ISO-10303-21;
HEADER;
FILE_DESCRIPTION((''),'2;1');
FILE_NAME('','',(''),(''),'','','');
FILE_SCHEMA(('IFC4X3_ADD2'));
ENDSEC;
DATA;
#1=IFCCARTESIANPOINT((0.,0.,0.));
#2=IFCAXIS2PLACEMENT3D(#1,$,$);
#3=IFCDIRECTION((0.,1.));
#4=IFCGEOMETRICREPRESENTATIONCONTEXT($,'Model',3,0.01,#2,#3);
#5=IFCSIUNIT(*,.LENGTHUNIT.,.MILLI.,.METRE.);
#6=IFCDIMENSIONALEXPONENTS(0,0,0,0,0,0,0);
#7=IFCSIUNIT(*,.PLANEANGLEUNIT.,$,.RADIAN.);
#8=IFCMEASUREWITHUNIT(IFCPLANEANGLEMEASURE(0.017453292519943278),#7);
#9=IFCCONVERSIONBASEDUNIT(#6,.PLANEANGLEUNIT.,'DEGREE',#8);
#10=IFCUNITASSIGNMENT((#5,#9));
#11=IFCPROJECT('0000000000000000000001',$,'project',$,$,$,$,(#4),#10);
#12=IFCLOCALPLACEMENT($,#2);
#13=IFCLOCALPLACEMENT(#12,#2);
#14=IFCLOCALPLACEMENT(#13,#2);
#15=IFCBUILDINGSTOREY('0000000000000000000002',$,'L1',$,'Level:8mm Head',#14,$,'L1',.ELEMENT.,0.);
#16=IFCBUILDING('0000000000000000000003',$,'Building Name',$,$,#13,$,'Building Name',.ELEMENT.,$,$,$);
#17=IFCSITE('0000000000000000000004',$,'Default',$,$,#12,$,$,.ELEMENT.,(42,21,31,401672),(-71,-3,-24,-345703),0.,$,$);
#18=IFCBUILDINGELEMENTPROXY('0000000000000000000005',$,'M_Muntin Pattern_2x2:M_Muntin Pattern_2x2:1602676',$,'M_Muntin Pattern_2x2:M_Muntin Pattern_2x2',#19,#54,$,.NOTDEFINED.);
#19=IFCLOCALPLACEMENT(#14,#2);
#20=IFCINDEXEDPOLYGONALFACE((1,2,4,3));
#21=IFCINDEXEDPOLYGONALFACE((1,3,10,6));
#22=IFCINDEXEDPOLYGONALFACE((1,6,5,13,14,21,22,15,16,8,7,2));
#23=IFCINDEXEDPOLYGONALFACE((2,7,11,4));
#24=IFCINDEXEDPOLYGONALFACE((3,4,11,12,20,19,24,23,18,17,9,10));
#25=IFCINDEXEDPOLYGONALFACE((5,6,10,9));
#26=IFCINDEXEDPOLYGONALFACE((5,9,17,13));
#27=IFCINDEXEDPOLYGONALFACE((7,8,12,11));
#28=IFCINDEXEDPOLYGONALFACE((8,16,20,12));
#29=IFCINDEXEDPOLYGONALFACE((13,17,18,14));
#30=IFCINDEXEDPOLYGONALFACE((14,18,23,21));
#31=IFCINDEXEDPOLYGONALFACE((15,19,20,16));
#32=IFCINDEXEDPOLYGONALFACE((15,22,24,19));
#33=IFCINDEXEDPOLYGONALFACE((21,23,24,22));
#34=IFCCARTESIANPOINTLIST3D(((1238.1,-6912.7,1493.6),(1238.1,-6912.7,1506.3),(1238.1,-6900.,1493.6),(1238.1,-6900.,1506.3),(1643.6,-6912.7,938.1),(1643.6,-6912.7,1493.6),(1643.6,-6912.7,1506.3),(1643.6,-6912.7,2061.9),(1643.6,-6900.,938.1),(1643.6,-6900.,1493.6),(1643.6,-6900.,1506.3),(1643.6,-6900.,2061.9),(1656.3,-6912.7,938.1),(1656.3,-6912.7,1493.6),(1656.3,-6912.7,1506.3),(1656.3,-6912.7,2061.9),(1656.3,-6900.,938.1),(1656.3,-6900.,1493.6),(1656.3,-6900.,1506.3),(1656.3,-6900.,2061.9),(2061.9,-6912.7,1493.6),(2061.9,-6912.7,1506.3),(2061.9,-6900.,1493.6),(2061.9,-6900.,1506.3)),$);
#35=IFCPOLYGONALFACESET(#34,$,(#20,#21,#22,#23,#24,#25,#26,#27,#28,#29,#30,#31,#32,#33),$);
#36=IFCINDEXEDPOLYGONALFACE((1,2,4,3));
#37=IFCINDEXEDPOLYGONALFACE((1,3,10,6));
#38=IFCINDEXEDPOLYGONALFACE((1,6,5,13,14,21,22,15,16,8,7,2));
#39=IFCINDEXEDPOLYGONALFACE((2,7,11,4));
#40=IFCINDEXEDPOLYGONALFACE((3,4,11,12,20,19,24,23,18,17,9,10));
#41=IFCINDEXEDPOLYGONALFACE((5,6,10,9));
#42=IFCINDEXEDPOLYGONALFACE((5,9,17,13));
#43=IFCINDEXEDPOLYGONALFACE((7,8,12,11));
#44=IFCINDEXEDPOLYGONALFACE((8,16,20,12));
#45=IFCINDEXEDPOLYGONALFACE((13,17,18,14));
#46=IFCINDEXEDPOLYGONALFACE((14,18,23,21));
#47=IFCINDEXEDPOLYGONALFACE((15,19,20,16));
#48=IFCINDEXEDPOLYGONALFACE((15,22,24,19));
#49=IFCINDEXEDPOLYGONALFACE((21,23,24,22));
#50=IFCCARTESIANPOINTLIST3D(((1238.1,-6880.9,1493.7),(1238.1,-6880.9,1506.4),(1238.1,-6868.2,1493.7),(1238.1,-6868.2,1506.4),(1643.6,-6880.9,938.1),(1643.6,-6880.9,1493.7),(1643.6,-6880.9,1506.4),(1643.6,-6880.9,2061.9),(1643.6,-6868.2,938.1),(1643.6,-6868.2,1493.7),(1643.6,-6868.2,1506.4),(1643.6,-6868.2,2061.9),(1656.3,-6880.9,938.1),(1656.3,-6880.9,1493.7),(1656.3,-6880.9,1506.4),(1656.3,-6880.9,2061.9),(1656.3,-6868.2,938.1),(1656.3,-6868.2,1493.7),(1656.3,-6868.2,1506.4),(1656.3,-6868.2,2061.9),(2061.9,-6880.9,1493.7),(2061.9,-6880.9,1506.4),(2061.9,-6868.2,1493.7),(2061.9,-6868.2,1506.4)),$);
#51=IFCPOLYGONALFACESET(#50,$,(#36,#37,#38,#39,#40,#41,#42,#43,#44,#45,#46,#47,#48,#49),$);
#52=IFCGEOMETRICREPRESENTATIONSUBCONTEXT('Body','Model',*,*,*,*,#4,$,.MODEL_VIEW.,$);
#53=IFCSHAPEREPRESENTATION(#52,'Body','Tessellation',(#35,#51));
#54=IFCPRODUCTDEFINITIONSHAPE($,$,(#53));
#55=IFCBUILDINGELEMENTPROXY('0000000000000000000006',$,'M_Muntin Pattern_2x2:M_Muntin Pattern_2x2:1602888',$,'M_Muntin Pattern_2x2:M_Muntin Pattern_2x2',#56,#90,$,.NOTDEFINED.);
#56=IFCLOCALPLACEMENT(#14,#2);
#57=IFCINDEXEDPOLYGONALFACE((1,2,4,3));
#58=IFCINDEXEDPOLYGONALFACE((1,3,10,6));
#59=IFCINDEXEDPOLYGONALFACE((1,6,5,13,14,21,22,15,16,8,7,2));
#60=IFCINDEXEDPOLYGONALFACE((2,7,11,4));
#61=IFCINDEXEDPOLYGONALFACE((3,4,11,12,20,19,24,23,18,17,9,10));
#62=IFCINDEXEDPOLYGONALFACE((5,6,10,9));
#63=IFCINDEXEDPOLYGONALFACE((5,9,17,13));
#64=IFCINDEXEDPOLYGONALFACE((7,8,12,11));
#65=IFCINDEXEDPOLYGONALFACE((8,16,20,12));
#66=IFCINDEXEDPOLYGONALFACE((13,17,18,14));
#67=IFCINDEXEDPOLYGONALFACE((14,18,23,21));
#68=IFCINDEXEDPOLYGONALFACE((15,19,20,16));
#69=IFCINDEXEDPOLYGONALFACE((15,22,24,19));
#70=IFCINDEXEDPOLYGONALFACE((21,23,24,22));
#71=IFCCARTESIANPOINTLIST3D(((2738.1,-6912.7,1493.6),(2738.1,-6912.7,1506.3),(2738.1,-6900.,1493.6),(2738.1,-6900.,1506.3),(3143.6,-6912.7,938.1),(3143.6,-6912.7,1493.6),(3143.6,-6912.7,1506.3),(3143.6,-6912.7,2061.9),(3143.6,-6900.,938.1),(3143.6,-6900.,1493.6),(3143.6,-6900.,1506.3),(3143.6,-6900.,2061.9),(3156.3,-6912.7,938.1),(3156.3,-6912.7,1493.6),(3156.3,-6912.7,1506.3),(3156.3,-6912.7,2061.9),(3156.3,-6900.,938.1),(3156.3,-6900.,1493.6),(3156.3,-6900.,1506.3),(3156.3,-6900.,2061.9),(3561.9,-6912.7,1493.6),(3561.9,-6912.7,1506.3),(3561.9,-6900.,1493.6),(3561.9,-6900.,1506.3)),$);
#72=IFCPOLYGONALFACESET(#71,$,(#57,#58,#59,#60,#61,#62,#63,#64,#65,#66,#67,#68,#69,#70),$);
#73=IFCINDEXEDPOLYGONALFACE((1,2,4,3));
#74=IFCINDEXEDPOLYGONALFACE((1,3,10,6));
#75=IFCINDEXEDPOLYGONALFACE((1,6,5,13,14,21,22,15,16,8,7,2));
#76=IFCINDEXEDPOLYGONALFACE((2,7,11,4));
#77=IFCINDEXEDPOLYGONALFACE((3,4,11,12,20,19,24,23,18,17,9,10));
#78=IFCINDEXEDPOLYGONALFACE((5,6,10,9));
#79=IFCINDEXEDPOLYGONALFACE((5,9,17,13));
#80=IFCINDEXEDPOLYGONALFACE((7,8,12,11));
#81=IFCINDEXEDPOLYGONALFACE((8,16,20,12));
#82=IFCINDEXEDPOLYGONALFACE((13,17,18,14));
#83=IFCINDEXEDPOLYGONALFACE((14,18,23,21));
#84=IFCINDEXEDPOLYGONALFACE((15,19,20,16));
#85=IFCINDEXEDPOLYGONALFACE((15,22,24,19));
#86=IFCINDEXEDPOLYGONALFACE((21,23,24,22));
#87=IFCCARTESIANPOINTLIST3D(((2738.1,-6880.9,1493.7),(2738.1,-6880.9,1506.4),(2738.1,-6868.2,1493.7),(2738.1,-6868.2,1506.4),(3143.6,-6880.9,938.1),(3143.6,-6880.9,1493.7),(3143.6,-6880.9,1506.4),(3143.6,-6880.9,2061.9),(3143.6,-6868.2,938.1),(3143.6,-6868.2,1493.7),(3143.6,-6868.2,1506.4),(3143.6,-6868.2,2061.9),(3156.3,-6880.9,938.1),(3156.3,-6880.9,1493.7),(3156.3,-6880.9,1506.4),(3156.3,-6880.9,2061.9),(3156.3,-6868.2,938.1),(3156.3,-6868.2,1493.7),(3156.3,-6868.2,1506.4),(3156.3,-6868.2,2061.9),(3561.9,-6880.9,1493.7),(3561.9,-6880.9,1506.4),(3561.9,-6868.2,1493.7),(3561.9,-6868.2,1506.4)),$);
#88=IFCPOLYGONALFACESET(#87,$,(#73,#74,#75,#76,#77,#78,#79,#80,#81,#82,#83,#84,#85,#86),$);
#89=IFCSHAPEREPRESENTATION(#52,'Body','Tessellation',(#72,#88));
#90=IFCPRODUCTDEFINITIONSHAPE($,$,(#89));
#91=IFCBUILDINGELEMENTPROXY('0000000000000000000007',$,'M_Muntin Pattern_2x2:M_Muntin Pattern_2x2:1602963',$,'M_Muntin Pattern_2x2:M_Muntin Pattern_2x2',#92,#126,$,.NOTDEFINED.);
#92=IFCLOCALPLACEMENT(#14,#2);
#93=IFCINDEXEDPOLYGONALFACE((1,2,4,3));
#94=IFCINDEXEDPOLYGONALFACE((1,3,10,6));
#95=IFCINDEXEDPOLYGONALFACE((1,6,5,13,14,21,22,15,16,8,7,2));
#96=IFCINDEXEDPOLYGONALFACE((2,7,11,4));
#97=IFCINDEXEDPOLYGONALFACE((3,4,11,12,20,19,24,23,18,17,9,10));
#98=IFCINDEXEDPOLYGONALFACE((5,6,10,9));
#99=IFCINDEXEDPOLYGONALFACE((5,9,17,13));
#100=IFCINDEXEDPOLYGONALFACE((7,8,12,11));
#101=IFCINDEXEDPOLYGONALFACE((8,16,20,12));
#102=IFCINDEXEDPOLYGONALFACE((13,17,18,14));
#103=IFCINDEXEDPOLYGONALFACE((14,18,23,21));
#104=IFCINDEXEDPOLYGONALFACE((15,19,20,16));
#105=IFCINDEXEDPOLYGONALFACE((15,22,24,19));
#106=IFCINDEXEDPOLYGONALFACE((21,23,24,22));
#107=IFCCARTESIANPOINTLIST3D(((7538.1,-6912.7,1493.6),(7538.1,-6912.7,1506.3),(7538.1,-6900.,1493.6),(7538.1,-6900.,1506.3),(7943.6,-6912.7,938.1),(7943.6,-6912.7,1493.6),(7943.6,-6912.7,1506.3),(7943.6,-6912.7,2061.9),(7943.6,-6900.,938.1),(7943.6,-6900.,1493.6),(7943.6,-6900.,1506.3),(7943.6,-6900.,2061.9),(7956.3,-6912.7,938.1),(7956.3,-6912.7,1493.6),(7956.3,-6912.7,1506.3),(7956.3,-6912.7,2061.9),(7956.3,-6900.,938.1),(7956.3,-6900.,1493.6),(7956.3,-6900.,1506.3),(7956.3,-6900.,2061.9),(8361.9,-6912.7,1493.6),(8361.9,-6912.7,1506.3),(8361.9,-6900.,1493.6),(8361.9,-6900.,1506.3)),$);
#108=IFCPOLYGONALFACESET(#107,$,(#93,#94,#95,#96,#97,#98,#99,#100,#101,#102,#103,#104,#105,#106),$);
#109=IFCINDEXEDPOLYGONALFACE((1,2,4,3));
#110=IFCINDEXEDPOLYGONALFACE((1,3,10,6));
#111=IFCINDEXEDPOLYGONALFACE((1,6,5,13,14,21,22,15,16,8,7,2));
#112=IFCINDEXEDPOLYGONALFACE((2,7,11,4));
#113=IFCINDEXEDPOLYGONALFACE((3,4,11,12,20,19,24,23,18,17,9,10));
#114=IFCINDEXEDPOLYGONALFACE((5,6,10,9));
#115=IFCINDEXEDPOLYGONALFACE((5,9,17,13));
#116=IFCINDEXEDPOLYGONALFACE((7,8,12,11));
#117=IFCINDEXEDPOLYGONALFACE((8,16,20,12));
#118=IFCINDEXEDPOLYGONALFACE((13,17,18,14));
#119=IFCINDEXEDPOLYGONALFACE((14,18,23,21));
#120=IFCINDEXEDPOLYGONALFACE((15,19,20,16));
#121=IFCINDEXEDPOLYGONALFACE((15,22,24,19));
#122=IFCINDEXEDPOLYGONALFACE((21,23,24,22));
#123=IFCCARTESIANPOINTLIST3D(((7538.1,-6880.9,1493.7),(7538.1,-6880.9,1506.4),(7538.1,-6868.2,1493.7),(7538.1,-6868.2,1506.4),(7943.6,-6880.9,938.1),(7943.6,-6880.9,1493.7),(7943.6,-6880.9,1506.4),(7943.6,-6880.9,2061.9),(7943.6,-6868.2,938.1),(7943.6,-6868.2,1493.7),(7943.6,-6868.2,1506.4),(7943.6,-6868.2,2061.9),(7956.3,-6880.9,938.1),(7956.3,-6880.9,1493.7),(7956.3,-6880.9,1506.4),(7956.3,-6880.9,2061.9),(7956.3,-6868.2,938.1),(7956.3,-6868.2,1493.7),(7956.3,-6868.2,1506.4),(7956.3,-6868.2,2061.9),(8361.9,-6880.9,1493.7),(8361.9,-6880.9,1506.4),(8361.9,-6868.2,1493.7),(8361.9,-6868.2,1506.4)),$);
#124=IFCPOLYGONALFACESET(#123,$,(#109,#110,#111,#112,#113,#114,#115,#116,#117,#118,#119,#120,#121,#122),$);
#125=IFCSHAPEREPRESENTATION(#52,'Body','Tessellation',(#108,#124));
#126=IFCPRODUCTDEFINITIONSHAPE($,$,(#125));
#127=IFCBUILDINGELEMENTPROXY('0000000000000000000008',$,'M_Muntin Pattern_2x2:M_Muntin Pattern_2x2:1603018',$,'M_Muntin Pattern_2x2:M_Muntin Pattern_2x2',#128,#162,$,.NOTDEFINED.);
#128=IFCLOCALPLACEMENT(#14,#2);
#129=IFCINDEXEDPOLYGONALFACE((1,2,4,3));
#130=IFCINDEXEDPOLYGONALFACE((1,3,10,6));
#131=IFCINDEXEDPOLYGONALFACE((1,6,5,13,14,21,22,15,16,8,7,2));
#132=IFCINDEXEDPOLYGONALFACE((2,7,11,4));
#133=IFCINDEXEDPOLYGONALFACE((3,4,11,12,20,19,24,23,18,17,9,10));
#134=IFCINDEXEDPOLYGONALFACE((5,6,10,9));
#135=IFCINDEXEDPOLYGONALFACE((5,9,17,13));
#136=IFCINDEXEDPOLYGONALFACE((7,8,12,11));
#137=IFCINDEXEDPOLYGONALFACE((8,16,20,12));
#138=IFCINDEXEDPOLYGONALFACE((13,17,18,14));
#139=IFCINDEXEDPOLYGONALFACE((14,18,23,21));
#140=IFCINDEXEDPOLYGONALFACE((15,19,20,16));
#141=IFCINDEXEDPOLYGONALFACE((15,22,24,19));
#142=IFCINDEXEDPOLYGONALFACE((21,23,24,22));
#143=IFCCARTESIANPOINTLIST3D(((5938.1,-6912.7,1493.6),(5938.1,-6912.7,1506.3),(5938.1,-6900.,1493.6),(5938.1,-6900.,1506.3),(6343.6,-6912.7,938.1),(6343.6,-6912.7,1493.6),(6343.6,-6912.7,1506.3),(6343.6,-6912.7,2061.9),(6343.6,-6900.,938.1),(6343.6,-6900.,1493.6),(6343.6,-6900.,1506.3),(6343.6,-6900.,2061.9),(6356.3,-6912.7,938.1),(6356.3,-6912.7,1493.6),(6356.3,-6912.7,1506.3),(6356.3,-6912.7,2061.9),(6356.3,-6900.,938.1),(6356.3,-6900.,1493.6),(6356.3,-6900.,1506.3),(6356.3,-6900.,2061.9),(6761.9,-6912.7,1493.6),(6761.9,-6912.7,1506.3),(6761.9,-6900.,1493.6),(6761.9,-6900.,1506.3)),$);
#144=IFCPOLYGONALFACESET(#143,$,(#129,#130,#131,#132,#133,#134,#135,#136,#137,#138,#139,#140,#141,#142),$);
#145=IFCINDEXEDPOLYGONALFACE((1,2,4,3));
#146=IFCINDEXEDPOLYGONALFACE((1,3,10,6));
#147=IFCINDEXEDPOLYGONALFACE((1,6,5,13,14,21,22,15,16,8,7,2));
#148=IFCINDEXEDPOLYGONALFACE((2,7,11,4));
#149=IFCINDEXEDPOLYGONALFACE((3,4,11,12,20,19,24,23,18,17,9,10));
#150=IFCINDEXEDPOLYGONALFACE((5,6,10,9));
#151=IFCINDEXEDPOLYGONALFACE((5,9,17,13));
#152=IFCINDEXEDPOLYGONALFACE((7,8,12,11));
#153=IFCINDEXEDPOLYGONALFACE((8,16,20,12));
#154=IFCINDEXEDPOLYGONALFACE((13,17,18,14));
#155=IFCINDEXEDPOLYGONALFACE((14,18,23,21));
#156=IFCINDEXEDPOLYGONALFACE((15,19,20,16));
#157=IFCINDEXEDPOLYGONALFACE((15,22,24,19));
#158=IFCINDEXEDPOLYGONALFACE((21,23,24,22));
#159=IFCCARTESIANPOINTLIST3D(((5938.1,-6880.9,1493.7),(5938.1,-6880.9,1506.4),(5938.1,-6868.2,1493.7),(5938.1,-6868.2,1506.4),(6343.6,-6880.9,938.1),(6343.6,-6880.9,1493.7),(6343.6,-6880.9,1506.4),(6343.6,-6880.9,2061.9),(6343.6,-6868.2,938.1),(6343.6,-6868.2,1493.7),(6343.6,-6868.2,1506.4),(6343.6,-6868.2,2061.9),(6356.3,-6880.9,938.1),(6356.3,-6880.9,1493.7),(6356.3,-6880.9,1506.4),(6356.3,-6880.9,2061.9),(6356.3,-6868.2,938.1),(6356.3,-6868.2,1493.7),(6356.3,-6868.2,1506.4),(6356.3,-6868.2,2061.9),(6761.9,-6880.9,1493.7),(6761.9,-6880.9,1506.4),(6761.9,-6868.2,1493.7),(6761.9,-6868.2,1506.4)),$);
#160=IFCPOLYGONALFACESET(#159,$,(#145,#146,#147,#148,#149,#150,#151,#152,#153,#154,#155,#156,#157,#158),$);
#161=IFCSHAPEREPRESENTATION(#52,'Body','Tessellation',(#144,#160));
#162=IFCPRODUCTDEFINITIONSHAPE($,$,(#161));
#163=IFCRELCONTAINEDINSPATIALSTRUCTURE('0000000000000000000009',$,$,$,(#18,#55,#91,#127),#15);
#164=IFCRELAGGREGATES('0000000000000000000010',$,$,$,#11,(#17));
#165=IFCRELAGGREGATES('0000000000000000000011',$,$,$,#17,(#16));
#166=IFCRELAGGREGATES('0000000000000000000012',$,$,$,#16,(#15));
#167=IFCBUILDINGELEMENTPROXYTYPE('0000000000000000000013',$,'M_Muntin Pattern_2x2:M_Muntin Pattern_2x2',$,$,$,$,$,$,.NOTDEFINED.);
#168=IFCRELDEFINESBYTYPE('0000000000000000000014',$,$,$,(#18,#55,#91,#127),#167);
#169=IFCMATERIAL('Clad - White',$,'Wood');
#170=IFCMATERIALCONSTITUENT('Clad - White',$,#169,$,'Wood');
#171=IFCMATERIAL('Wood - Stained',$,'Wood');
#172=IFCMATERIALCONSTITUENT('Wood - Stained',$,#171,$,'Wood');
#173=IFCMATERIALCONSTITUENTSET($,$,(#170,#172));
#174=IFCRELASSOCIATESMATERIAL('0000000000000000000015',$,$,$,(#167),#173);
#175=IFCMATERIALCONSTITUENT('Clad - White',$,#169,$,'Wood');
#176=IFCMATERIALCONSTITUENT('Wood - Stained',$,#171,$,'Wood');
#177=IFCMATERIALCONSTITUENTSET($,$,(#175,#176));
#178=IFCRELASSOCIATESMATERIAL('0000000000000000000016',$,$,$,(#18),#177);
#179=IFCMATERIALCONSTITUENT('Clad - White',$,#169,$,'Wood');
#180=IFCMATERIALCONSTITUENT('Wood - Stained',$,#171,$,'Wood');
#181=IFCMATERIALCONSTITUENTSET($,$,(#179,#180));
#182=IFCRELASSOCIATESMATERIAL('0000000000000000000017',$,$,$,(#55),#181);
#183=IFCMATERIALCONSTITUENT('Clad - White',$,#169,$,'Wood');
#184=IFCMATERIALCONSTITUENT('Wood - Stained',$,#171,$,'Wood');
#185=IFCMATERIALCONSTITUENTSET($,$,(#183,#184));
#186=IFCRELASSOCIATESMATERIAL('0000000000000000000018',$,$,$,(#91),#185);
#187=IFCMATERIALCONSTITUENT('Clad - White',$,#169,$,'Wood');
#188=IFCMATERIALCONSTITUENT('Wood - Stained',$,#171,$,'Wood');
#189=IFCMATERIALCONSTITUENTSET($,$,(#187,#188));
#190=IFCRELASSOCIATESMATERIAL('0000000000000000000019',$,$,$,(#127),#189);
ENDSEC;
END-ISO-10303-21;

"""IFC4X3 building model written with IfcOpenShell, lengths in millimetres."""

from ifc_helpers import new_model, entity, si_unit, converted_unit, direction, frame, origin, place, context, subcontext, project, spatial, polyline, outline, extrude, source, transform, mapped, material, constituent, constituent_set, type_object, type_shapes, element, save


model = new_model("IFC4X3")

# Units and contexts
model_context = context("Model", 3, precision=0.01, world=origin(), true_north=direction((0.0, 1.0)))
body_context = subcontext(model_context, "Body", "Model", "MODEL_VIEW")
ifc_project = project(units=[si_unit("LENGTHUNIT", "METRE", prefix="MILLI"), converted_unit("PLANEANGLEUNIT", "DEGREE", entity("IfcPlaneAngleMeasure", 0.017453292519943278), si_unit("PLANEANGLEUNIT", "RADIAN"), dimensions=[0, 0, 0, 0, 0, 0, 0])], contexts=[model_context])

# Site, building, storey
site_placement = place(None, origin())
site = spatial("IfcSite", under=ifc_project, at=site_placement, Name="Default", CompositionType="ELEMENT", RefLatitude=(42, 21, 31, 401672), RefLongitude=(-71, -3, -24, -345703), RefElevation=0.0)
building_placement = place(site_placement, origin())
building = spatial("IfcBuilding", under=site, at=building_placement, Name="Building Name", LongName="Building Name", CompositionType="ELEMENT")
storey_placement = place(building_placement, origin())
storey = spatial("IfcBuildingStorey", under=building, at=storey_placement, Name="L1", ObjectType="Level:8mm Head", LongName="L1", CompositionType="ELEMENT", Elevation=0.0)

# Building element proxies
ifc_material_1 = material(Name="Clad - White", Category="Wood")
ifc_constituent_1 = constituent(ifc_material_1, Name="Clad - White", Category="Wood")
ifc_material_2 = material(Name="Wood - Stained", Category="Wood")
ifc_constituent_2 = constituent(ifc_material_2, Name="Wood - Stained", Category="Wood")
ifc_constituent_set_1 = constituent_set(constituents=[ifc_constituent_1, ifc_constituent_2])
ifc_constituent_3 = constituent(ifc_material_1, Name="Clad - White", Category="Wood")
ifc_constituent_4 = constituent(ifc_material_2, Name="Wood - Stained", Category="Wood")
ifc_constituent_set_2 = constituent_set(constituents=[ifc_constituent_3, ifc_constituent_4])
building_element_proxy_type_1 = type_object("IfcBuildingElementProxyType", Name="M_Muntin Pattern_2x2:M_Muntin Pattern_2x2", PredefinedType="NOTDEFINED", material=ifc_constituent_set_2)
shared_shape_1 = source(origin(), body_context, "Body", "SweptSolid", [
    extrude(outline(polyline([(6.4, -6.4), (561.9, -6.4), (561.9, 6.3), (6.4, 6.3), (6.4, 411.9), (-6.3, 411.9), (-6.3, 6.3), (-561.9, 6.3), (-561.9, -6.4), (-6.3, -6.4), (-6.3, -411.9), (6.4, -411.9), (6.4, -6.4)])), frame((0.0, -22.2, 561.9), z_axis=(0.0, 1.0, 0.0), x_axis=(0.0, 0.0, 1.0)), (0.0, 0.0, 1.0), 12.7),
    extrude(outline(polyline([(6.4, -6.4), (561.9, -6.4), (561.9, 6.3), (6.4, 6.3), (6.4, 411.9), (-6.3, 411.9), (-6.3, 6.3), (-561.9, 6.3), (-561.9, -6.4), (-6.3, -6.4), (-6.3, -411.9), (6.4, -411.9), (6.4, -6.4)])), frame((0.0, 9.5, 561.9), z_axis=(0.0, 1.0, 0.0), x_axis=(0.0, 0.0, 1.0)), (0.0, 0.0, 1.0), 12.7),
])
type_shapes(building_element_proxy_type_1, [shared_shape_1])
proxy_1_placement = place(storey_placement, frame((1650.0, -6890.5, 938.1)))
element("IfcBuildingElementProxy", 1, at=proxy_1_placement, inside=storey, type_object=building_element_proxy_type_1, material=ifc_constituent_set_1, Name="M_Muntin Pattern_2x2:M_Muntin Pattern_2x2:1602676", ObjectType="M_Muntin Pattern_2x2:M_Muntin Pattern_2x2", PredefinedType="NOTDEFINED", context=body_context, shape_type="MappedRepresentation", body=[
    mapped(shared_shape_1, transform((0.0, 0.0, 0.0), scale=1.0)),
])
ifc_constituent_5 = constituent(ifc_material_1, Name="Clad - White", Category="Wood")
ifc_constituent_6 = constituent(ifc_material_2, Name="Wood - Stained", Category="Wood")
ifc_constituent_set_3 = constituent_set(constituents=[ifc_constituent_5, ifc_constituent_6])
proxy_2_placement = place(storey_placement, frame((3150.0, -6890.5, 938.1)))
element("IfcBuildingElementProxy", 2, at=proxy_2_placement, inside=storey, type_object=building_element_proxy_type_1, material=ifc_constituent_set_3, Name="M_Muntin Pattern_2x2:M_Muntin Pattern_2x2:1602888", ObjectType="M_Muntin Pattern_2x2:M_Muntin Pattern_2x2", PredefinedType="NOTDEFINED", context=body_context, shape_type="MappedRepresentation", body=[
    mapped(shared_shape_1, transform((0.0, 0.0, 0.0), scale=1.0)),
])
ifc_constituent_7 = constituent(ifc_material_1, Name="Clad - White", Category="Wood")
ifc_constituent_8 = constituent(ifc_material_2, Name="Wood - Stained", Category="Wood")
ifc_constituent_set_4 = constituent_set(constituents=[ifc_constituent_7, ifc_constituent_8])
proxy_3_placement = place(storey_placement, frame((7950.0, -6890.5, 938.1)))
element("IfcBuildingElementProxy", 3, at=proxy_3_placement, inside=storey, type_object=building_element_proxy_type_1, material=ifc_constituent_set_4, Name="M_Muntin Pattern_2x2:M_Muntin Pattern_2x2:1602963", ObjectType="M_Muntin Pattern_2x2:M_Muntin Pattern_2x2", PredefinedType="NOTDEFINED", context=body_context, shape_type="MappedRepresentation", body=[
    mapped(shared_shape_1, transform((0.0, 0.0, 0.0), scale=1.0)),
])
ifc_constituent_9 = constituent(ifc_material_1, Name="Clad - White", Category="Wood")
ifc_constituent_10 = constituent(ifc_material_2, Name="Wood - Stained", Category="Wood")
ifc_constituent_set_5 = constituent_set(constituents=[ifc_constituent_9, ifc_constituent_10])
proxy_4_placement = place(storey_placement, frame((6350.0, -6890.5, 938.1)))
element("IfcBuildingElementProxy", 4, at=proxy_4_placement, inside=storey, type_object=building_element_proxy_type_1, material=ifc_constituent_set_5, Name="M_Muntin Pattern_2x2:M_Muntin Pattern_2x2:1603018", ObjectType="M_Muntin Pattern_2x2:M_Muntin Pattern_2x2", PredefinedType="NOTDEFINED", context=body_context, shape_type="MappedRepresentation", body=[
    mapped(shared_shape_1, transform((0.0, 0.0, 0.0), scale=1.0)),
])

save(model, "model.ifc")
